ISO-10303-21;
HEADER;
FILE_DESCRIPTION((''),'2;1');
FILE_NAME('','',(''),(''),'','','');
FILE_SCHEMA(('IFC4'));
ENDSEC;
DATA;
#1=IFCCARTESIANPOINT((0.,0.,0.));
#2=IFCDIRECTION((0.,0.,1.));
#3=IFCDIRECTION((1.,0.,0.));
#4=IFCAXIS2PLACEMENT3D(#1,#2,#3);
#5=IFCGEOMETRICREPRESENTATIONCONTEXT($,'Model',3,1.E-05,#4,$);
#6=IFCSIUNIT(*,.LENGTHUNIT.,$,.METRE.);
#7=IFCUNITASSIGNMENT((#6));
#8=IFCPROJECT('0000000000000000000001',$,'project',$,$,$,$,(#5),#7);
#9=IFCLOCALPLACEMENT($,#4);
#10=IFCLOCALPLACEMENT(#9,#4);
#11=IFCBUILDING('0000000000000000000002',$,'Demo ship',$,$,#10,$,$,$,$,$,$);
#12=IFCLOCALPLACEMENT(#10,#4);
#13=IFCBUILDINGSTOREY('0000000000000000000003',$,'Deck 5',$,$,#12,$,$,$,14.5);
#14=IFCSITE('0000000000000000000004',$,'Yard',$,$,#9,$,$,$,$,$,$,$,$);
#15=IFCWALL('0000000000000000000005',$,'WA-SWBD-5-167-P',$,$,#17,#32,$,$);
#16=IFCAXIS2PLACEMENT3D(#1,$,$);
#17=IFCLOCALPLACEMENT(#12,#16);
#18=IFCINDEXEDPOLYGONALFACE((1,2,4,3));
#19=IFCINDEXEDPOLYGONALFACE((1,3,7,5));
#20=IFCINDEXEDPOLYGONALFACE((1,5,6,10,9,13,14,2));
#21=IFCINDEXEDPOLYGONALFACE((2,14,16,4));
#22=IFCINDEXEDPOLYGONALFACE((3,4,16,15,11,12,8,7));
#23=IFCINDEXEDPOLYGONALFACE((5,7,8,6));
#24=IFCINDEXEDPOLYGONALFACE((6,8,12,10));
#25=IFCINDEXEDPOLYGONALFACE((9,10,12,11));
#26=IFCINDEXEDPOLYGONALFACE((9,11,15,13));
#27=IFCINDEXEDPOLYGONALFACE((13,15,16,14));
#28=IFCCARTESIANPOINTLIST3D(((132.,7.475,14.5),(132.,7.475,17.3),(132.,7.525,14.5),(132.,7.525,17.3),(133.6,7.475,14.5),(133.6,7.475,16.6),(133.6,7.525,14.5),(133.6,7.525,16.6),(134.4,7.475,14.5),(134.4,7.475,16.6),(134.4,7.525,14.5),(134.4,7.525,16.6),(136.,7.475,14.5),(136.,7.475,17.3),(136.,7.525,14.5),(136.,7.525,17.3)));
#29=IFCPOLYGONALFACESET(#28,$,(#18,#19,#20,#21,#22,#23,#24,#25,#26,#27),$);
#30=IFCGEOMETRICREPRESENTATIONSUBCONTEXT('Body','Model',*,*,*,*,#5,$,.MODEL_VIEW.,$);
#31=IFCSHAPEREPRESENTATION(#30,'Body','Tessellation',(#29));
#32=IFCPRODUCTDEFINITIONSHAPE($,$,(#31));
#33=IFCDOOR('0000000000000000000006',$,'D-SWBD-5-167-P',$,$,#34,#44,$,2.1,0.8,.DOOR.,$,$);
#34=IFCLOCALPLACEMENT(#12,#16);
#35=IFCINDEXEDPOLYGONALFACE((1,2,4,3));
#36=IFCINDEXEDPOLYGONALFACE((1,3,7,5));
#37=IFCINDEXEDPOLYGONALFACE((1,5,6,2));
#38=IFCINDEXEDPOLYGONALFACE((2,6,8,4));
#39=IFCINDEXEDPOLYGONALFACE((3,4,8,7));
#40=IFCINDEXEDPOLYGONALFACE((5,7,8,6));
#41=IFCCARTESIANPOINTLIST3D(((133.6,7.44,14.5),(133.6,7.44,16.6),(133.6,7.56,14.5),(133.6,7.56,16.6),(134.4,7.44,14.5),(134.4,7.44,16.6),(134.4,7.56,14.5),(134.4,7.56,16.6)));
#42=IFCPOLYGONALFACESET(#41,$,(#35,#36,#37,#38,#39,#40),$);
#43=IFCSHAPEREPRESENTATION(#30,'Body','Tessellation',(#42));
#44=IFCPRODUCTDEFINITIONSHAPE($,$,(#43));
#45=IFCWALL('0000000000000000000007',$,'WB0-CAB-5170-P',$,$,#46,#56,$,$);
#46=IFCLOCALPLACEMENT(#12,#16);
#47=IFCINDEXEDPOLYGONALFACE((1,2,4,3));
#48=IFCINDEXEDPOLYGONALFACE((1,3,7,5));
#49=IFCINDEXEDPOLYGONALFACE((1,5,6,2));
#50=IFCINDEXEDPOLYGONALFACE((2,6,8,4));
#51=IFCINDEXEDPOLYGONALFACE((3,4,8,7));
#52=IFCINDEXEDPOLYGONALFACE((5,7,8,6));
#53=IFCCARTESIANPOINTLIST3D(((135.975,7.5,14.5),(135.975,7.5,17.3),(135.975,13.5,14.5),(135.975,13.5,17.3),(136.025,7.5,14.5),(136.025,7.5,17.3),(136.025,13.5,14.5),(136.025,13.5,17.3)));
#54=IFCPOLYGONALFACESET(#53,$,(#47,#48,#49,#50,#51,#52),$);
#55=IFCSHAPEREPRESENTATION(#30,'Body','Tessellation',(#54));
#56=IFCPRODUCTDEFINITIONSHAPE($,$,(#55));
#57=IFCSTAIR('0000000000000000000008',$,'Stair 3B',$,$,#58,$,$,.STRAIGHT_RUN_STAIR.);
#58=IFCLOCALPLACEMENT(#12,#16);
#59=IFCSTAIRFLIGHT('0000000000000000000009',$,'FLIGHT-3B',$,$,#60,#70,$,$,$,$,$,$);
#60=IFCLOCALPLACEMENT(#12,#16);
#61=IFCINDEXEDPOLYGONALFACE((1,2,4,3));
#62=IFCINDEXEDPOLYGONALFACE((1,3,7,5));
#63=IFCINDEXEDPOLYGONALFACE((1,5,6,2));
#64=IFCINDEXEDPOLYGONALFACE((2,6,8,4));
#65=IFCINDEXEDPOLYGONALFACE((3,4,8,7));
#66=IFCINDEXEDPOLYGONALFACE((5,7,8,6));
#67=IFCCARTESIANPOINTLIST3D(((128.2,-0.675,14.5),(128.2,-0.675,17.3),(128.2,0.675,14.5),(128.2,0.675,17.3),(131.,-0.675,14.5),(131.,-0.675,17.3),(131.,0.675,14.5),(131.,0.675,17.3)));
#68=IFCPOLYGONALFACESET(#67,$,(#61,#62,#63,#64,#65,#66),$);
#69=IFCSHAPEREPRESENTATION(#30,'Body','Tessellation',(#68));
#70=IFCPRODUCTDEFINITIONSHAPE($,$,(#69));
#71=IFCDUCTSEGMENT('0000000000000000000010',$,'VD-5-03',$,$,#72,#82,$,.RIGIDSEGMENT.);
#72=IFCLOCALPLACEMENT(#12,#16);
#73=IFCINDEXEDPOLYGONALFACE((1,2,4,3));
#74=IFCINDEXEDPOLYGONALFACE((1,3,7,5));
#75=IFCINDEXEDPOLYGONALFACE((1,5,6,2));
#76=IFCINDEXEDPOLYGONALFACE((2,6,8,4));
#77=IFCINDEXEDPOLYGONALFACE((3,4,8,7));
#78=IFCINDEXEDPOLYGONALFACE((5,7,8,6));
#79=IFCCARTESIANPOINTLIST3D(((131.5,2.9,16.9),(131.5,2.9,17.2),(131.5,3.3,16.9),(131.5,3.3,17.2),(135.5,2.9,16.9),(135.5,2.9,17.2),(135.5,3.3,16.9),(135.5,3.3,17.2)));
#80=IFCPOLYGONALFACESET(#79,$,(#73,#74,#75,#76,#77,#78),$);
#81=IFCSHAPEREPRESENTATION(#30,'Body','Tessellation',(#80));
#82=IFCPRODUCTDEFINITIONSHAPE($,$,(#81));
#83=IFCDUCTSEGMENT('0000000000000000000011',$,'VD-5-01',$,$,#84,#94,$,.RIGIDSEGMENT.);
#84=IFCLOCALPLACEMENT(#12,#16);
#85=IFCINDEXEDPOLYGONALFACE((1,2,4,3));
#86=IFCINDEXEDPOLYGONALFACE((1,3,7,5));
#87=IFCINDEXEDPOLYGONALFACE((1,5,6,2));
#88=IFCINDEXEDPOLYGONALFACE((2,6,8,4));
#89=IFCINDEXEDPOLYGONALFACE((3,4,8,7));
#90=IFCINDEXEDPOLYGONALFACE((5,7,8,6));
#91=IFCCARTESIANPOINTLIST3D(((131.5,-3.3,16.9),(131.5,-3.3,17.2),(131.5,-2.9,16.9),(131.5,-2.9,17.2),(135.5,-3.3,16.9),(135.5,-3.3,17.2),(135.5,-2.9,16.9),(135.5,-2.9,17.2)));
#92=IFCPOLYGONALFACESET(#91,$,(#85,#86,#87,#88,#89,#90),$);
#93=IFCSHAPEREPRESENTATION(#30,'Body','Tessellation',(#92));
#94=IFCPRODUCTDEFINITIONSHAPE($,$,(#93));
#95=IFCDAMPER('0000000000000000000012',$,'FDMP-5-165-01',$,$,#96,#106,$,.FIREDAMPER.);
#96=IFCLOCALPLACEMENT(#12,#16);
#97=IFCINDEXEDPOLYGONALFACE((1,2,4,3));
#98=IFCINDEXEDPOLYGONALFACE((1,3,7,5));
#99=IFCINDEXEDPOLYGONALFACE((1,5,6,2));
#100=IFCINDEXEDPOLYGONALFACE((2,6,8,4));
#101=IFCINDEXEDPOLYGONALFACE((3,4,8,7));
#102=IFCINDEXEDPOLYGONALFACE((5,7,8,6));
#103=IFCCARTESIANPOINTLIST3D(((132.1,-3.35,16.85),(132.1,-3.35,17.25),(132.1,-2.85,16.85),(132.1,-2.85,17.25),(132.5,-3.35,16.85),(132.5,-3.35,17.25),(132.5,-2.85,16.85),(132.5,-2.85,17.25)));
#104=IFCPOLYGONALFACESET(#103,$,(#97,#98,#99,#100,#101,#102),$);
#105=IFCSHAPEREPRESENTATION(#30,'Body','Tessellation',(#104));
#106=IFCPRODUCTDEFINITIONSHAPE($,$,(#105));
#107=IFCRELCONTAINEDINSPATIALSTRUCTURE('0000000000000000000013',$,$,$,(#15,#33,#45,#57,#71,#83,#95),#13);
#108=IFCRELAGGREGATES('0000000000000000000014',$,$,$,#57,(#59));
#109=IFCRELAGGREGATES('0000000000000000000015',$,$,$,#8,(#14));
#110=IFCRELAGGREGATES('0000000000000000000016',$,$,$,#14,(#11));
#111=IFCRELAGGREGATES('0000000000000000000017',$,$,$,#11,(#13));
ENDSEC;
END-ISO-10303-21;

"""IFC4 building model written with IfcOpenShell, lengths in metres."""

from ifc_helpers import new_model, si_unit, frame, frame_2d, origin, origin_with_axes, place, context, subcontext, project, spatial, rectangle, extrude, element, fill, aggregate, save


model = new_model("IFC4")

# Units and contexts
model_context = context("Model", 3, precision=1e-05, world=origin_with_axes())
body_context = subcontext(model_context, "Body", "Model", "MODEL_VIEW")
ifc_project = project(units=[si_unit("LENGTHUNIT", "METRE")], contexts=[model_context])

# Site, building, storey
site_placement = place(None, origin_with_axes())
site = spatial("IfcSite", under=ifc_project, at=site_placement, Name="Yard")
building_placement = place(site_placement, origin_with_axes())
building = spatial("IfcBuilding", under=site, at=building_placement, Name="Demo ship")
storey_placement = place(building_placement, origin_with_axes())
storey = spatial("IfcBuildingStorey", under=building, at=storey_placement, Name="Deck 5", Elevation=14.5)

# Wall, opening, door
wall_1_placement = place(storey_placement, frame((132.0, 7.475, 14.5), z_axis=(0.0, 0.0, 1.0), x_axis=(1.0, 0.0, 0.0)))
wall_1 = element("IfcWall", 1, at=wall_1_placement, inside=storey, Name="WA-SWBD-5-167-P", context=body_context, shape_type="SweptSolid", body=[
    extrude(rectangle(XDim=4.0, YDim=0.05, at=frame_2d((2.0, 0.025))), origin(), (0.0, 0.0, 1.0), 2.8),
])
opening_placement = place(None, frame((133.6, 7.44, 14.5), z_axis=(0.0, 0.0, 1.0), x_axis=(1.0, 0.0, 0.0)))
opening = element("IfcOpeningElement", 2, at=opening_placement, cuts=wall_1, context=body_context, shape_type="SweptSolid", body=[
    extrude(rectangle(XDim=0.8, YDim=0.12, at=frame_2d((0.4, 0.06))), origin(), (0.0, 0.0, 1.0), 2.1),
])
door_placement = place(storey_placement, frame((133.6, 7.44, 14.5), z_axis=(0.0, 0.0, 1.0), x_axis=(1.0, 0.0, 0.0)))
door = element("IfcDoor", 3, at=door_placement, inside=storey, Name="D-SWBD-5-167-P", OverallHeight=2.1, OverallWidth=0.8, PredefinedType="DOOR", context=body_context, shape_type="SweptSolid", body=[
    extrude(rectangle(XDim=0.8, YDim=0.12, at=frame_2d((0.4, 0.06))), origin(), (0.0, 0.0, 1.0), 2.1),
])
fill(opening, door)

# Wall
wall_2_placement = place(storey_placement, frame((135.975, 7.5, 14.5), z_axis=(0.0, 0.0, 1.0), x_axis=(1.0, 0.0, 0.0)))
element("IfcWall", 4, at=wall_2_placement, inside=storey, Name="WB0-CAB-5170-P", context=body_context, shape_type="SweptSolid", body=[
    extrude(rectangle(XDim=0.05, YDim=6.0, at=frame_2d((0.025, 3.0))), origin(), (0.0, 0.0, 1.0), 2.8),
])

# Stair, stair flight
stair_placement = place(storey_placement, frame((128.2, -0.675, 14.5), z_axis=(0.0, 0.0, 1.0), x_axis=(1.0, 0.0, 0.0)))
stair = element("IfcStair", 5, at=stair_placement, inside=storey, Name="Stair 3B", PredefinedType="STRAIGHT_RUN_STAIR")
stair_flight_placement = place(stair_placement, origin_with_axes())
stair_flight = element("IfcStairFlight", 6, at=stair_flight_placement, Name="FLIGHT-3B", context=body_context, shape_type="SweptSolid", body=[
    extrude(rectangle(XDim=2.8, YDim=1.35, at=frame_2d((1.4, 0.675))), origin(), (0.0, 0.0, 1.0), 2.8),
])
aggregate(stair, [stair_flight])

# Duct segments
for number, where, z_axis, x_axis, name in (
    (7, (131.5, 2.9, 16.9), (0.0, 0.0, 1.0), (1.0, 0.0, 0.0), "VD-5-03"),
    (8, (131.5, -3.3, 16.9), (0.0, 0.0, 1.0), (1.0, 0.0, 0.0), "VD-5-01"),
):
    element("IfcDuctSegment", number, at=place(storey_placement, frame(where, z_axis=z_axis, x_axis=x_axis)), inside=storey, Name=name, PredefinedType="RIGIDSEGMENT", context=body_context, shape_type="SweptSolid", body=[
        extrude(rectangle(XDim=4.0, YDim=0.4, at=frame_2d((2.0, 0.2))), origin(), (0.0, 0.0, 1.0), 0.3),
    ])

# Damper
damper_placement = place(storey_placement, frame((132.1, -3.35, 16.85), z_axis=(0.0, 0.0, 1.0), x_axis=(1.0, 0.0, 0.0)))
element("IfcDamper", 9, at=damper_placement, inside=storey, Name="FDMP-5-165-01", PredefinedType="FIREDAMPER", context=body_context, shape_type="SweptSolid", body=[
    extrude(rectangle(XDim=0.4, YDim=0.5, at=frame_2d((0.2, 0.25))), origin(), (0.0, 0.0, 1.0), 0.4),
])

save(model, "model.ifc")
